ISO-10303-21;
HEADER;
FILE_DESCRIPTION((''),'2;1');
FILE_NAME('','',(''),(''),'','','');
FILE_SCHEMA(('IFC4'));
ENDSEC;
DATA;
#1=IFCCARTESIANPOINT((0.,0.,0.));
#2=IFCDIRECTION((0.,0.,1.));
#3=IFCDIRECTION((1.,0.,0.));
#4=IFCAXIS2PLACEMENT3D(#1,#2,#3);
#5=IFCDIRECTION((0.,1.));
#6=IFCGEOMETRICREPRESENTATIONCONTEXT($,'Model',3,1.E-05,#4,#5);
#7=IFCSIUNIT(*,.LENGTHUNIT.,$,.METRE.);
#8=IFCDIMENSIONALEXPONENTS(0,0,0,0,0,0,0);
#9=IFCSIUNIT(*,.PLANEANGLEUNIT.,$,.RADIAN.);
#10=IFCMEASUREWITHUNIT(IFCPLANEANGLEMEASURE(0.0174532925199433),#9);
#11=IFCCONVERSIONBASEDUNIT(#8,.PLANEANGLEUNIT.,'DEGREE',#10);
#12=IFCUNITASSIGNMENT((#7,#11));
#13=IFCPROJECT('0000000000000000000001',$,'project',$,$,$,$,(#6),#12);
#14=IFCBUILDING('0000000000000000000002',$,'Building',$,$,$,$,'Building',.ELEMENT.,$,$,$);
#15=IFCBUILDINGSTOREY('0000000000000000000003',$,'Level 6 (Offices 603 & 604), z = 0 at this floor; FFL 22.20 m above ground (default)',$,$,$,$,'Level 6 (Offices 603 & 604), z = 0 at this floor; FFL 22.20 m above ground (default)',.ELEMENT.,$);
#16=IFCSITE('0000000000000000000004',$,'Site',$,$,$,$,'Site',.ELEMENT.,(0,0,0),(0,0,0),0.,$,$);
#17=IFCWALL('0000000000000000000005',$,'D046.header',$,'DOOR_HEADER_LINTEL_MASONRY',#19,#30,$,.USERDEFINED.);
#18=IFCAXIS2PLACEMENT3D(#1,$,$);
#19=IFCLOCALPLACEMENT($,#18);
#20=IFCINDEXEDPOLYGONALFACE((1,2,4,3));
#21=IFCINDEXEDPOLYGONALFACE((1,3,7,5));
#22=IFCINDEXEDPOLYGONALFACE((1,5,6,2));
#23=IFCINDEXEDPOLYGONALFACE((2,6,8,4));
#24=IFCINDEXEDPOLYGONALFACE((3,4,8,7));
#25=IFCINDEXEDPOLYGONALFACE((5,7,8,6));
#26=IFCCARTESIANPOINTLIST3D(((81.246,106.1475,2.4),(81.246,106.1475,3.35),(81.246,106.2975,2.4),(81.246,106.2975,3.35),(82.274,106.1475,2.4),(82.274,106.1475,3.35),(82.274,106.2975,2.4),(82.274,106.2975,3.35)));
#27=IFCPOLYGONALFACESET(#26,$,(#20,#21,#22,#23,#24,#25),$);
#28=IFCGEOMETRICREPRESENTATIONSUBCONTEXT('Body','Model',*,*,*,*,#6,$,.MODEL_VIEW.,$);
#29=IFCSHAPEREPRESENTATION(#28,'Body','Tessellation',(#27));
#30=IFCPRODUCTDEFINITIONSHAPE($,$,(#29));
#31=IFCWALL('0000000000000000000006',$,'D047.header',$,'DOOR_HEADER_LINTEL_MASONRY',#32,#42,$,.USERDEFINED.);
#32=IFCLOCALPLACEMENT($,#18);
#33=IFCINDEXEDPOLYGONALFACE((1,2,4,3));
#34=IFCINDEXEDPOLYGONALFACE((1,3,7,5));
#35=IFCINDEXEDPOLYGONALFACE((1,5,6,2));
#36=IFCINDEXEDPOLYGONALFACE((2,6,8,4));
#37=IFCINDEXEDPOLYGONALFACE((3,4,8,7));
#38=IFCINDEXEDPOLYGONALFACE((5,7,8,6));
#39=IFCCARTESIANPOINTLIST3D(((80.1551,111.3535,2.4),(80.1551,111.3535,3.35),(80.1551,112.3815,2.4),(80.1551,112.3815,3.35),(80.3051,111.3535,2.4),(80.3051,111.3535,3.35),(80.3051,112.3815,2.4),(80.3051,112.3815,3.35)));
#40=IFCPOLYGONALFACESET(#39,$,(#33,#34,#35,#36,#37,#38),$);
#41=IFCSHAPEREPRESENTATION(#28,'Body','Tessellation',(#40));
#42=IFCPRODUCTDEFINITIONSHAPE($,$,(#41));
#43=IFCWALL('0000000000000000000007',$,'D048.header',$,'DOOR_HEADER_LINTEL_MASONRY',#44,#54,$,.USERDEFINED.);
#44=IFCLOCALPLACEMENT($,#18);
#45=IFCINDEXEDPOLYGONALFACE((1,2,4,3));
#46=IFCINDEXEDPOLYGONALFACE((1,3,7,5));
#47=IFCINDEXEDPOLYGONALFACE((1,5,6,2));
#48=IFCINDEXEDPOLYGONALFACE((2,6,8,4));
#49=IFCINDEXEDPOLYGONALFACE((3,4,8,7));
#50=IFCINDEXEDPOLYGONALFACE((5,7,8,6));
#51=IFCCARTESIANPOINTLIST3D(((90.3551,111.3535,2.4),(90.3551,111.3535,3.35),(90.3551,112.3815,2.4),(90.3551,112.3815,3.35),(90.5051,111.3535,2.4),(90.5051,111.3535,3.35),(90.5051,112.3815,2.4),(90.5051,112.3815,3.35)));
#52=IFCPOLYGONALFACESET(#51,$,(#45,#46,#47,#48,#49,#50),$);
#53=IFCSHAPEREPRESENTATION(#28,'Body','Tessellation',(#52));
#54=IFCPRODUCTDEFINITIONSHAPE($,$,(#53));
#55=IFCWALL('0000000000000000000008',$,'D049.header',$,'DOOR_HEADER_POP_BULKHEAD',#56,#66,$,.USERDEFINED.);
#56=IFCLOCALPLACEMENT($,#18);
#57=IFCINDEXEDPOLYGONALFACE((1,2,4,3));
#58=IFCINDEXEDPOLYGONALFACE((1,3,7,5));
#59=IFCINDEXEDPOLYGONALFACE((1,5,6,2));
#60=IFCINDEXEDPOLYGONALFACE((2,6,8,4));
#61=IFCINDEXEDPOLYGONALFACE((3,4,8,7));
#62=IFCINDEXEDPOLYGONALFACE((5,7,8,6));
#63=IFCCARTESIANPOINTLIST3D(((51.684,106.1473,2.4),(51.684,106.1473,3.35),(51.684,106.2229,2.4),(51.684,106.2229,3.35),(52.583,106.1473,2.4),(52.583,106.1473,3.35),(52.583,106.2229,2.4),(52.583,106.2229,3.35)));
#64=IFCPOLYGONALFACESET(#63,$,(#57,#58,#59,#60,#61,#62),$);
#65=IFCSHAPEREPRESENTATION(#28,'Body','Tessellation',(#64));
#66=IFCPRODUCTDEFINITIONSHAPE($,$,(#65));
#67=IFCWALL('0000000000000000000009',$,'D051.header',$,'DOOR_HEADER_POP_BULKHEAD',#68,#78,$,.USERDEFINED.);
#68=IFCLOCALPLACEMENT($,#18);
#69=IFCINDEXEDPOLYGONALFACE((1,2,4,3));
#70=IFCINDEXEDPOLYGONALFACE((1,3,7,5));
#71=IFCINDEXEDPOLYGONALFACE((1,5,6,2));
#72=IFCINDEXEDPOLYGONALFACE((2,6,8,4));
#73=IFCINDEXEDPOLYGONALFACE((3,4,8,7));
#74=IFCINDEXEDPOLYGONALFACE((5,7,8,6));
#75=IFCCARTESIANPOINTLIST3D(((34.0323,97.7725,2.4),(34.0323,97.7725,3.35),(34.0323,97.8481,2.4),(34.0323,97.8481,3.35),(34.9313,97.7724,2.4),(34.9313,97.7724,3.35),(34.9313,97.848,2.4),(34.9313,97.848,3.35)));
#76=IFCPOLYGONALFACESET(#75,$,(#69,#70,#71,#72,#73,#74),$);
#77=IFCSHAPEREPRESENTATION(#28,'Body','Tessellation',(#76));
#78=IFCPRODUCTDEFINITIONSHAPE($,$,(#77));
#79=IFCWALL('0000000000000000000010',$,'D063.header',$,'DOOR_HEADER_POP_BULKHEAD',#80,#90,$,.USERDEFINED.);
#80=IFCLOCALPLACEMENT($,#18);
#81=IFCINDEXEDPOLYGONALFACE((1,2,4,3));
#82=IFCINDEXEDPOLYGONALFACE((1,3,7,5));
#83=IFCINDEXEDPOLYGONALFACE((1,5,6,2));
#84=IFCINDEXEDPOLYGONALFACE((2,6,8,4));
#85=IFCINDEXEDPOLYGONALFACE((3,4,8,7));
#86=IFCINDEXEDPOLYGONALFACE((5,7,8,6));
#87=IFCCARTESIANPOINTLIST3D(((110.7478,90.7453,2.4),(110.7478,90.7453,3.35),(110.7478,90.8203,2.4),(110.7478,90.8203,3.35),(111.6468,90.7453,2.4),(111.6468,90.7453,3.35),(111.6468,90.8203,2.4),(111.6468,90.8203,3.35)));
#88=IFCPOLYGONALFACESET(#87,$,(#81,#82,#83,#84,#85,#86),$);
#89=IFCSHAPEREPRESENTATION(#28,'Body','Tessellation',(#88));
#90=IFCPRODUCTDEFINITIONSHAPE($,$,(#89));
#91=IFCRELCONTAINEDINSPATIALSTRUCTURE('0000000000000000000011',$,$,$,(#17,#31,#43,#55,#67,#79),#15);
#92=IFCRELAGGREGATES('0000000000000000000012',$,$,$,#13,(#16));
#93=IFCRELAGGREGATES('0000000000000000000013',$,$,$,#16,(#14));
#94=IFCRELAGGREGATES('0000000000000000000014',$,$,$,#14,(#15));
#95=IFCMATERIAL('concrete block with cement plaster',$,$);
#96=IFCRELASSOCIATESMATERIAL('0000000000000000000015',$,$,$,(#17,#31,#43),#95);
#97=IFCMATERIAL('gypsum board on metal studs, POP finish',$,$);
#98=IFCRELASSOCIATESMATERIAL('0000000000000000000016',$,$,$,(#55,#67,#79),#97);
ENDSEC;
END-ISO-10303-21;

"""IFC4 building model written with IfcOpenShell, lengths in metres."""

from ifc_helpers import new_model, entity, si_unit, converted_unit, direction, frame, frame_2d, origin_with_axes, place, context, subcontext, project, spatial, rectangle, extrude, material, element, save


model = new_model("IFC4")

# Units and contexts
model_context = context("Model", 3, precision=1e-05, world=origin_with_axes(), true_north=direction((0.0, 1.0)))
body_context = subcontext(model_context, "Body", "Model", "MODEL_VIEW")
ifc_project = project(units=[si_unit("LENGTHUNIT", "METRE"), converted_unit("PLANEANGLEUNIT", "DEGREE", entity("IfcPlaneAngleMeasure", 0.0174532925199433), si_unit("PLANEANGLEUNIT", "RADIAN"), dimensions=[0, 0, 0, 0, 0, 0, 0])], contexts=[model_context])

# Site, building, storey
site = spatial("IfcSite", under=ifc_project, Name="Site", LongName="Site", CompositionType="ELEMENT", RefLatitude=(0, 0, 0), RefLongitude=(0, 0, 0), RefElevation=0.0)
building = spatial("IfcBuilding", under=site, Name="Building", LongName="Building", CompositionType="ELEMENT")
storey = spatial("IfcBuildingStorey", under=building, Name="Level 6 (Offices 603 & 604), z = 0 at this floor; FFL 22.20 m above ground (default)", LongName="Level 6 (Offices 603 & 604), z = 0 at this floor; FFL 22.20 m above ground (default)", CompositionType="ELEMENT")

# Shared definitions
placement = place(None, origin_with_axes())

# Walls
ifc_material_1 = material(Name="gypsum board on metal studs, POP finish")
ifc_material_2 = material(Name="concrete block with cement plaster")
element("IfcWall", 1, at=placement, inside=storey, material=ifc_material_2, Name="D046.header", ObjectType="DOOR_HEADER_LINTEL_MASONRY", PredefinedType="USERDEFINED", context=body_context, shape_type="SweptSolid", body=[
    extrude(rectangle(XDim=1.028, YDim=0.15, at=frame_2d((0.0, 0.0), x_axis=(1.0, 0.0))), frame((81.76, 106.2225, 2.4), z_axis=(0.0, 0.0, 1.0), x_axis=(1.0, 0.0, 0.0)), (0.0, 0.0, 1.0), 0.95),
])
element("IfcWall", 2, at=placement, inside=storey, material=ifc_material_2, Name="D047.header", ObjectType="DOOR_HEADER_LINTEL_MASONRY", PredefinedType="USERDEFINED", context=body_context, shape_type="SweptSolid", body=[
    extrude(rectangle(XDim=1.028, YDim=0.15, at=frame_2d((0.0, 0.0), x_axis=(0.0, 1.0))), frame((80.2301, 111.8675, 2.4), z_axis=(0.0, 0.0, 1.0), x_axis=(1.0, 0.0, 0.0)), (0.0, 0.0, 1.0), 0.95),
])
element("IfcWall", 3, at=placement, inside=storey, material=ifc_material_2, Name="D048.header", ObjectType="DOOR_HEADER_LINTEL_MASONRY", PredefinedType="USERDEFINED", context=body_context, shape_type="SweptSolid", body=[
    extrude(rectangle(XDim=1.028, YDim=0.15, at=frame_2d((0.0, 0.0), x_axis=(0.0, 1.0))), frame((90.4301, 111.8675, 2.4), z_axis=(0.0, 0.0, 1.0), x_axis=(1.0, 0.0, 0.0)), (0.0, 0.0, 1.0), 0.95),
])
element("IfcWall", 4, at=placement, inside=storey, material=ifc_material_1, Name="D049.header", ObjectType="DOOR_HEADER_POP_BULKHEAD", PredefinedType="USERDEFINED", context=body_context, shape_type="SweptSolid", body=[
    extrude(rectangle(XDim=0.899, YDim=0.0756, at=frame_2d((0.0, 0.0), x_axis=(1.0, 0.0))), frame((52.1335, 106.1851, 2.4), z_axis=(0.0, 0.0, 1.0), x_axis=(1.0, 0.0, 0.0)), (0.0, 0.0, 1.0), 0.95),
])
element("IfcWall", 5, at=placement, inside=storey, material=ifc_material_1, Name="D051.header", ObjectType="DOOR_HEADER_POP_BULKHEAD", PredefinedType="USERDEFINED", context=body_context, shape_type="SweptSolid", body=[
    extrude(rectangle(XDim=0.899, YDim=0.0756, at=frame_2d((0.0, 0.0), x_axis=(1.0, -0.00012))), frame((34.4818, 97.8102, 2.4), z_axis=(0.0, 0.0, 1.0), x_axis=(1.0, 0.0, 0.0)), (0.0, 0.0, 1.0), 0.95),
])
element("IfcWall", 6, at=placement, inside=storey, material=ifc_material_1, Name="D063.header", ObjectType="DOOR_HEADER_POP_BULKHEAD", PredefinedType="USERDEFINED", context=body_context, shape_type="SweptSolid", body=[
    extrude(rectangle(XDim=0.899, YDim=0.075, at=frame_2d((0.0, 0.0), x_axis=(1.0, 0.0))), frame((111.1973, 90.7828, 2.4), z_axis=(0.0, 0.0, 1.0), x_axis=(1.0, 0.0, 0.0)), (0.0, 0.0, 1.0), 0.95),
])

save(model, "model.ifc")
